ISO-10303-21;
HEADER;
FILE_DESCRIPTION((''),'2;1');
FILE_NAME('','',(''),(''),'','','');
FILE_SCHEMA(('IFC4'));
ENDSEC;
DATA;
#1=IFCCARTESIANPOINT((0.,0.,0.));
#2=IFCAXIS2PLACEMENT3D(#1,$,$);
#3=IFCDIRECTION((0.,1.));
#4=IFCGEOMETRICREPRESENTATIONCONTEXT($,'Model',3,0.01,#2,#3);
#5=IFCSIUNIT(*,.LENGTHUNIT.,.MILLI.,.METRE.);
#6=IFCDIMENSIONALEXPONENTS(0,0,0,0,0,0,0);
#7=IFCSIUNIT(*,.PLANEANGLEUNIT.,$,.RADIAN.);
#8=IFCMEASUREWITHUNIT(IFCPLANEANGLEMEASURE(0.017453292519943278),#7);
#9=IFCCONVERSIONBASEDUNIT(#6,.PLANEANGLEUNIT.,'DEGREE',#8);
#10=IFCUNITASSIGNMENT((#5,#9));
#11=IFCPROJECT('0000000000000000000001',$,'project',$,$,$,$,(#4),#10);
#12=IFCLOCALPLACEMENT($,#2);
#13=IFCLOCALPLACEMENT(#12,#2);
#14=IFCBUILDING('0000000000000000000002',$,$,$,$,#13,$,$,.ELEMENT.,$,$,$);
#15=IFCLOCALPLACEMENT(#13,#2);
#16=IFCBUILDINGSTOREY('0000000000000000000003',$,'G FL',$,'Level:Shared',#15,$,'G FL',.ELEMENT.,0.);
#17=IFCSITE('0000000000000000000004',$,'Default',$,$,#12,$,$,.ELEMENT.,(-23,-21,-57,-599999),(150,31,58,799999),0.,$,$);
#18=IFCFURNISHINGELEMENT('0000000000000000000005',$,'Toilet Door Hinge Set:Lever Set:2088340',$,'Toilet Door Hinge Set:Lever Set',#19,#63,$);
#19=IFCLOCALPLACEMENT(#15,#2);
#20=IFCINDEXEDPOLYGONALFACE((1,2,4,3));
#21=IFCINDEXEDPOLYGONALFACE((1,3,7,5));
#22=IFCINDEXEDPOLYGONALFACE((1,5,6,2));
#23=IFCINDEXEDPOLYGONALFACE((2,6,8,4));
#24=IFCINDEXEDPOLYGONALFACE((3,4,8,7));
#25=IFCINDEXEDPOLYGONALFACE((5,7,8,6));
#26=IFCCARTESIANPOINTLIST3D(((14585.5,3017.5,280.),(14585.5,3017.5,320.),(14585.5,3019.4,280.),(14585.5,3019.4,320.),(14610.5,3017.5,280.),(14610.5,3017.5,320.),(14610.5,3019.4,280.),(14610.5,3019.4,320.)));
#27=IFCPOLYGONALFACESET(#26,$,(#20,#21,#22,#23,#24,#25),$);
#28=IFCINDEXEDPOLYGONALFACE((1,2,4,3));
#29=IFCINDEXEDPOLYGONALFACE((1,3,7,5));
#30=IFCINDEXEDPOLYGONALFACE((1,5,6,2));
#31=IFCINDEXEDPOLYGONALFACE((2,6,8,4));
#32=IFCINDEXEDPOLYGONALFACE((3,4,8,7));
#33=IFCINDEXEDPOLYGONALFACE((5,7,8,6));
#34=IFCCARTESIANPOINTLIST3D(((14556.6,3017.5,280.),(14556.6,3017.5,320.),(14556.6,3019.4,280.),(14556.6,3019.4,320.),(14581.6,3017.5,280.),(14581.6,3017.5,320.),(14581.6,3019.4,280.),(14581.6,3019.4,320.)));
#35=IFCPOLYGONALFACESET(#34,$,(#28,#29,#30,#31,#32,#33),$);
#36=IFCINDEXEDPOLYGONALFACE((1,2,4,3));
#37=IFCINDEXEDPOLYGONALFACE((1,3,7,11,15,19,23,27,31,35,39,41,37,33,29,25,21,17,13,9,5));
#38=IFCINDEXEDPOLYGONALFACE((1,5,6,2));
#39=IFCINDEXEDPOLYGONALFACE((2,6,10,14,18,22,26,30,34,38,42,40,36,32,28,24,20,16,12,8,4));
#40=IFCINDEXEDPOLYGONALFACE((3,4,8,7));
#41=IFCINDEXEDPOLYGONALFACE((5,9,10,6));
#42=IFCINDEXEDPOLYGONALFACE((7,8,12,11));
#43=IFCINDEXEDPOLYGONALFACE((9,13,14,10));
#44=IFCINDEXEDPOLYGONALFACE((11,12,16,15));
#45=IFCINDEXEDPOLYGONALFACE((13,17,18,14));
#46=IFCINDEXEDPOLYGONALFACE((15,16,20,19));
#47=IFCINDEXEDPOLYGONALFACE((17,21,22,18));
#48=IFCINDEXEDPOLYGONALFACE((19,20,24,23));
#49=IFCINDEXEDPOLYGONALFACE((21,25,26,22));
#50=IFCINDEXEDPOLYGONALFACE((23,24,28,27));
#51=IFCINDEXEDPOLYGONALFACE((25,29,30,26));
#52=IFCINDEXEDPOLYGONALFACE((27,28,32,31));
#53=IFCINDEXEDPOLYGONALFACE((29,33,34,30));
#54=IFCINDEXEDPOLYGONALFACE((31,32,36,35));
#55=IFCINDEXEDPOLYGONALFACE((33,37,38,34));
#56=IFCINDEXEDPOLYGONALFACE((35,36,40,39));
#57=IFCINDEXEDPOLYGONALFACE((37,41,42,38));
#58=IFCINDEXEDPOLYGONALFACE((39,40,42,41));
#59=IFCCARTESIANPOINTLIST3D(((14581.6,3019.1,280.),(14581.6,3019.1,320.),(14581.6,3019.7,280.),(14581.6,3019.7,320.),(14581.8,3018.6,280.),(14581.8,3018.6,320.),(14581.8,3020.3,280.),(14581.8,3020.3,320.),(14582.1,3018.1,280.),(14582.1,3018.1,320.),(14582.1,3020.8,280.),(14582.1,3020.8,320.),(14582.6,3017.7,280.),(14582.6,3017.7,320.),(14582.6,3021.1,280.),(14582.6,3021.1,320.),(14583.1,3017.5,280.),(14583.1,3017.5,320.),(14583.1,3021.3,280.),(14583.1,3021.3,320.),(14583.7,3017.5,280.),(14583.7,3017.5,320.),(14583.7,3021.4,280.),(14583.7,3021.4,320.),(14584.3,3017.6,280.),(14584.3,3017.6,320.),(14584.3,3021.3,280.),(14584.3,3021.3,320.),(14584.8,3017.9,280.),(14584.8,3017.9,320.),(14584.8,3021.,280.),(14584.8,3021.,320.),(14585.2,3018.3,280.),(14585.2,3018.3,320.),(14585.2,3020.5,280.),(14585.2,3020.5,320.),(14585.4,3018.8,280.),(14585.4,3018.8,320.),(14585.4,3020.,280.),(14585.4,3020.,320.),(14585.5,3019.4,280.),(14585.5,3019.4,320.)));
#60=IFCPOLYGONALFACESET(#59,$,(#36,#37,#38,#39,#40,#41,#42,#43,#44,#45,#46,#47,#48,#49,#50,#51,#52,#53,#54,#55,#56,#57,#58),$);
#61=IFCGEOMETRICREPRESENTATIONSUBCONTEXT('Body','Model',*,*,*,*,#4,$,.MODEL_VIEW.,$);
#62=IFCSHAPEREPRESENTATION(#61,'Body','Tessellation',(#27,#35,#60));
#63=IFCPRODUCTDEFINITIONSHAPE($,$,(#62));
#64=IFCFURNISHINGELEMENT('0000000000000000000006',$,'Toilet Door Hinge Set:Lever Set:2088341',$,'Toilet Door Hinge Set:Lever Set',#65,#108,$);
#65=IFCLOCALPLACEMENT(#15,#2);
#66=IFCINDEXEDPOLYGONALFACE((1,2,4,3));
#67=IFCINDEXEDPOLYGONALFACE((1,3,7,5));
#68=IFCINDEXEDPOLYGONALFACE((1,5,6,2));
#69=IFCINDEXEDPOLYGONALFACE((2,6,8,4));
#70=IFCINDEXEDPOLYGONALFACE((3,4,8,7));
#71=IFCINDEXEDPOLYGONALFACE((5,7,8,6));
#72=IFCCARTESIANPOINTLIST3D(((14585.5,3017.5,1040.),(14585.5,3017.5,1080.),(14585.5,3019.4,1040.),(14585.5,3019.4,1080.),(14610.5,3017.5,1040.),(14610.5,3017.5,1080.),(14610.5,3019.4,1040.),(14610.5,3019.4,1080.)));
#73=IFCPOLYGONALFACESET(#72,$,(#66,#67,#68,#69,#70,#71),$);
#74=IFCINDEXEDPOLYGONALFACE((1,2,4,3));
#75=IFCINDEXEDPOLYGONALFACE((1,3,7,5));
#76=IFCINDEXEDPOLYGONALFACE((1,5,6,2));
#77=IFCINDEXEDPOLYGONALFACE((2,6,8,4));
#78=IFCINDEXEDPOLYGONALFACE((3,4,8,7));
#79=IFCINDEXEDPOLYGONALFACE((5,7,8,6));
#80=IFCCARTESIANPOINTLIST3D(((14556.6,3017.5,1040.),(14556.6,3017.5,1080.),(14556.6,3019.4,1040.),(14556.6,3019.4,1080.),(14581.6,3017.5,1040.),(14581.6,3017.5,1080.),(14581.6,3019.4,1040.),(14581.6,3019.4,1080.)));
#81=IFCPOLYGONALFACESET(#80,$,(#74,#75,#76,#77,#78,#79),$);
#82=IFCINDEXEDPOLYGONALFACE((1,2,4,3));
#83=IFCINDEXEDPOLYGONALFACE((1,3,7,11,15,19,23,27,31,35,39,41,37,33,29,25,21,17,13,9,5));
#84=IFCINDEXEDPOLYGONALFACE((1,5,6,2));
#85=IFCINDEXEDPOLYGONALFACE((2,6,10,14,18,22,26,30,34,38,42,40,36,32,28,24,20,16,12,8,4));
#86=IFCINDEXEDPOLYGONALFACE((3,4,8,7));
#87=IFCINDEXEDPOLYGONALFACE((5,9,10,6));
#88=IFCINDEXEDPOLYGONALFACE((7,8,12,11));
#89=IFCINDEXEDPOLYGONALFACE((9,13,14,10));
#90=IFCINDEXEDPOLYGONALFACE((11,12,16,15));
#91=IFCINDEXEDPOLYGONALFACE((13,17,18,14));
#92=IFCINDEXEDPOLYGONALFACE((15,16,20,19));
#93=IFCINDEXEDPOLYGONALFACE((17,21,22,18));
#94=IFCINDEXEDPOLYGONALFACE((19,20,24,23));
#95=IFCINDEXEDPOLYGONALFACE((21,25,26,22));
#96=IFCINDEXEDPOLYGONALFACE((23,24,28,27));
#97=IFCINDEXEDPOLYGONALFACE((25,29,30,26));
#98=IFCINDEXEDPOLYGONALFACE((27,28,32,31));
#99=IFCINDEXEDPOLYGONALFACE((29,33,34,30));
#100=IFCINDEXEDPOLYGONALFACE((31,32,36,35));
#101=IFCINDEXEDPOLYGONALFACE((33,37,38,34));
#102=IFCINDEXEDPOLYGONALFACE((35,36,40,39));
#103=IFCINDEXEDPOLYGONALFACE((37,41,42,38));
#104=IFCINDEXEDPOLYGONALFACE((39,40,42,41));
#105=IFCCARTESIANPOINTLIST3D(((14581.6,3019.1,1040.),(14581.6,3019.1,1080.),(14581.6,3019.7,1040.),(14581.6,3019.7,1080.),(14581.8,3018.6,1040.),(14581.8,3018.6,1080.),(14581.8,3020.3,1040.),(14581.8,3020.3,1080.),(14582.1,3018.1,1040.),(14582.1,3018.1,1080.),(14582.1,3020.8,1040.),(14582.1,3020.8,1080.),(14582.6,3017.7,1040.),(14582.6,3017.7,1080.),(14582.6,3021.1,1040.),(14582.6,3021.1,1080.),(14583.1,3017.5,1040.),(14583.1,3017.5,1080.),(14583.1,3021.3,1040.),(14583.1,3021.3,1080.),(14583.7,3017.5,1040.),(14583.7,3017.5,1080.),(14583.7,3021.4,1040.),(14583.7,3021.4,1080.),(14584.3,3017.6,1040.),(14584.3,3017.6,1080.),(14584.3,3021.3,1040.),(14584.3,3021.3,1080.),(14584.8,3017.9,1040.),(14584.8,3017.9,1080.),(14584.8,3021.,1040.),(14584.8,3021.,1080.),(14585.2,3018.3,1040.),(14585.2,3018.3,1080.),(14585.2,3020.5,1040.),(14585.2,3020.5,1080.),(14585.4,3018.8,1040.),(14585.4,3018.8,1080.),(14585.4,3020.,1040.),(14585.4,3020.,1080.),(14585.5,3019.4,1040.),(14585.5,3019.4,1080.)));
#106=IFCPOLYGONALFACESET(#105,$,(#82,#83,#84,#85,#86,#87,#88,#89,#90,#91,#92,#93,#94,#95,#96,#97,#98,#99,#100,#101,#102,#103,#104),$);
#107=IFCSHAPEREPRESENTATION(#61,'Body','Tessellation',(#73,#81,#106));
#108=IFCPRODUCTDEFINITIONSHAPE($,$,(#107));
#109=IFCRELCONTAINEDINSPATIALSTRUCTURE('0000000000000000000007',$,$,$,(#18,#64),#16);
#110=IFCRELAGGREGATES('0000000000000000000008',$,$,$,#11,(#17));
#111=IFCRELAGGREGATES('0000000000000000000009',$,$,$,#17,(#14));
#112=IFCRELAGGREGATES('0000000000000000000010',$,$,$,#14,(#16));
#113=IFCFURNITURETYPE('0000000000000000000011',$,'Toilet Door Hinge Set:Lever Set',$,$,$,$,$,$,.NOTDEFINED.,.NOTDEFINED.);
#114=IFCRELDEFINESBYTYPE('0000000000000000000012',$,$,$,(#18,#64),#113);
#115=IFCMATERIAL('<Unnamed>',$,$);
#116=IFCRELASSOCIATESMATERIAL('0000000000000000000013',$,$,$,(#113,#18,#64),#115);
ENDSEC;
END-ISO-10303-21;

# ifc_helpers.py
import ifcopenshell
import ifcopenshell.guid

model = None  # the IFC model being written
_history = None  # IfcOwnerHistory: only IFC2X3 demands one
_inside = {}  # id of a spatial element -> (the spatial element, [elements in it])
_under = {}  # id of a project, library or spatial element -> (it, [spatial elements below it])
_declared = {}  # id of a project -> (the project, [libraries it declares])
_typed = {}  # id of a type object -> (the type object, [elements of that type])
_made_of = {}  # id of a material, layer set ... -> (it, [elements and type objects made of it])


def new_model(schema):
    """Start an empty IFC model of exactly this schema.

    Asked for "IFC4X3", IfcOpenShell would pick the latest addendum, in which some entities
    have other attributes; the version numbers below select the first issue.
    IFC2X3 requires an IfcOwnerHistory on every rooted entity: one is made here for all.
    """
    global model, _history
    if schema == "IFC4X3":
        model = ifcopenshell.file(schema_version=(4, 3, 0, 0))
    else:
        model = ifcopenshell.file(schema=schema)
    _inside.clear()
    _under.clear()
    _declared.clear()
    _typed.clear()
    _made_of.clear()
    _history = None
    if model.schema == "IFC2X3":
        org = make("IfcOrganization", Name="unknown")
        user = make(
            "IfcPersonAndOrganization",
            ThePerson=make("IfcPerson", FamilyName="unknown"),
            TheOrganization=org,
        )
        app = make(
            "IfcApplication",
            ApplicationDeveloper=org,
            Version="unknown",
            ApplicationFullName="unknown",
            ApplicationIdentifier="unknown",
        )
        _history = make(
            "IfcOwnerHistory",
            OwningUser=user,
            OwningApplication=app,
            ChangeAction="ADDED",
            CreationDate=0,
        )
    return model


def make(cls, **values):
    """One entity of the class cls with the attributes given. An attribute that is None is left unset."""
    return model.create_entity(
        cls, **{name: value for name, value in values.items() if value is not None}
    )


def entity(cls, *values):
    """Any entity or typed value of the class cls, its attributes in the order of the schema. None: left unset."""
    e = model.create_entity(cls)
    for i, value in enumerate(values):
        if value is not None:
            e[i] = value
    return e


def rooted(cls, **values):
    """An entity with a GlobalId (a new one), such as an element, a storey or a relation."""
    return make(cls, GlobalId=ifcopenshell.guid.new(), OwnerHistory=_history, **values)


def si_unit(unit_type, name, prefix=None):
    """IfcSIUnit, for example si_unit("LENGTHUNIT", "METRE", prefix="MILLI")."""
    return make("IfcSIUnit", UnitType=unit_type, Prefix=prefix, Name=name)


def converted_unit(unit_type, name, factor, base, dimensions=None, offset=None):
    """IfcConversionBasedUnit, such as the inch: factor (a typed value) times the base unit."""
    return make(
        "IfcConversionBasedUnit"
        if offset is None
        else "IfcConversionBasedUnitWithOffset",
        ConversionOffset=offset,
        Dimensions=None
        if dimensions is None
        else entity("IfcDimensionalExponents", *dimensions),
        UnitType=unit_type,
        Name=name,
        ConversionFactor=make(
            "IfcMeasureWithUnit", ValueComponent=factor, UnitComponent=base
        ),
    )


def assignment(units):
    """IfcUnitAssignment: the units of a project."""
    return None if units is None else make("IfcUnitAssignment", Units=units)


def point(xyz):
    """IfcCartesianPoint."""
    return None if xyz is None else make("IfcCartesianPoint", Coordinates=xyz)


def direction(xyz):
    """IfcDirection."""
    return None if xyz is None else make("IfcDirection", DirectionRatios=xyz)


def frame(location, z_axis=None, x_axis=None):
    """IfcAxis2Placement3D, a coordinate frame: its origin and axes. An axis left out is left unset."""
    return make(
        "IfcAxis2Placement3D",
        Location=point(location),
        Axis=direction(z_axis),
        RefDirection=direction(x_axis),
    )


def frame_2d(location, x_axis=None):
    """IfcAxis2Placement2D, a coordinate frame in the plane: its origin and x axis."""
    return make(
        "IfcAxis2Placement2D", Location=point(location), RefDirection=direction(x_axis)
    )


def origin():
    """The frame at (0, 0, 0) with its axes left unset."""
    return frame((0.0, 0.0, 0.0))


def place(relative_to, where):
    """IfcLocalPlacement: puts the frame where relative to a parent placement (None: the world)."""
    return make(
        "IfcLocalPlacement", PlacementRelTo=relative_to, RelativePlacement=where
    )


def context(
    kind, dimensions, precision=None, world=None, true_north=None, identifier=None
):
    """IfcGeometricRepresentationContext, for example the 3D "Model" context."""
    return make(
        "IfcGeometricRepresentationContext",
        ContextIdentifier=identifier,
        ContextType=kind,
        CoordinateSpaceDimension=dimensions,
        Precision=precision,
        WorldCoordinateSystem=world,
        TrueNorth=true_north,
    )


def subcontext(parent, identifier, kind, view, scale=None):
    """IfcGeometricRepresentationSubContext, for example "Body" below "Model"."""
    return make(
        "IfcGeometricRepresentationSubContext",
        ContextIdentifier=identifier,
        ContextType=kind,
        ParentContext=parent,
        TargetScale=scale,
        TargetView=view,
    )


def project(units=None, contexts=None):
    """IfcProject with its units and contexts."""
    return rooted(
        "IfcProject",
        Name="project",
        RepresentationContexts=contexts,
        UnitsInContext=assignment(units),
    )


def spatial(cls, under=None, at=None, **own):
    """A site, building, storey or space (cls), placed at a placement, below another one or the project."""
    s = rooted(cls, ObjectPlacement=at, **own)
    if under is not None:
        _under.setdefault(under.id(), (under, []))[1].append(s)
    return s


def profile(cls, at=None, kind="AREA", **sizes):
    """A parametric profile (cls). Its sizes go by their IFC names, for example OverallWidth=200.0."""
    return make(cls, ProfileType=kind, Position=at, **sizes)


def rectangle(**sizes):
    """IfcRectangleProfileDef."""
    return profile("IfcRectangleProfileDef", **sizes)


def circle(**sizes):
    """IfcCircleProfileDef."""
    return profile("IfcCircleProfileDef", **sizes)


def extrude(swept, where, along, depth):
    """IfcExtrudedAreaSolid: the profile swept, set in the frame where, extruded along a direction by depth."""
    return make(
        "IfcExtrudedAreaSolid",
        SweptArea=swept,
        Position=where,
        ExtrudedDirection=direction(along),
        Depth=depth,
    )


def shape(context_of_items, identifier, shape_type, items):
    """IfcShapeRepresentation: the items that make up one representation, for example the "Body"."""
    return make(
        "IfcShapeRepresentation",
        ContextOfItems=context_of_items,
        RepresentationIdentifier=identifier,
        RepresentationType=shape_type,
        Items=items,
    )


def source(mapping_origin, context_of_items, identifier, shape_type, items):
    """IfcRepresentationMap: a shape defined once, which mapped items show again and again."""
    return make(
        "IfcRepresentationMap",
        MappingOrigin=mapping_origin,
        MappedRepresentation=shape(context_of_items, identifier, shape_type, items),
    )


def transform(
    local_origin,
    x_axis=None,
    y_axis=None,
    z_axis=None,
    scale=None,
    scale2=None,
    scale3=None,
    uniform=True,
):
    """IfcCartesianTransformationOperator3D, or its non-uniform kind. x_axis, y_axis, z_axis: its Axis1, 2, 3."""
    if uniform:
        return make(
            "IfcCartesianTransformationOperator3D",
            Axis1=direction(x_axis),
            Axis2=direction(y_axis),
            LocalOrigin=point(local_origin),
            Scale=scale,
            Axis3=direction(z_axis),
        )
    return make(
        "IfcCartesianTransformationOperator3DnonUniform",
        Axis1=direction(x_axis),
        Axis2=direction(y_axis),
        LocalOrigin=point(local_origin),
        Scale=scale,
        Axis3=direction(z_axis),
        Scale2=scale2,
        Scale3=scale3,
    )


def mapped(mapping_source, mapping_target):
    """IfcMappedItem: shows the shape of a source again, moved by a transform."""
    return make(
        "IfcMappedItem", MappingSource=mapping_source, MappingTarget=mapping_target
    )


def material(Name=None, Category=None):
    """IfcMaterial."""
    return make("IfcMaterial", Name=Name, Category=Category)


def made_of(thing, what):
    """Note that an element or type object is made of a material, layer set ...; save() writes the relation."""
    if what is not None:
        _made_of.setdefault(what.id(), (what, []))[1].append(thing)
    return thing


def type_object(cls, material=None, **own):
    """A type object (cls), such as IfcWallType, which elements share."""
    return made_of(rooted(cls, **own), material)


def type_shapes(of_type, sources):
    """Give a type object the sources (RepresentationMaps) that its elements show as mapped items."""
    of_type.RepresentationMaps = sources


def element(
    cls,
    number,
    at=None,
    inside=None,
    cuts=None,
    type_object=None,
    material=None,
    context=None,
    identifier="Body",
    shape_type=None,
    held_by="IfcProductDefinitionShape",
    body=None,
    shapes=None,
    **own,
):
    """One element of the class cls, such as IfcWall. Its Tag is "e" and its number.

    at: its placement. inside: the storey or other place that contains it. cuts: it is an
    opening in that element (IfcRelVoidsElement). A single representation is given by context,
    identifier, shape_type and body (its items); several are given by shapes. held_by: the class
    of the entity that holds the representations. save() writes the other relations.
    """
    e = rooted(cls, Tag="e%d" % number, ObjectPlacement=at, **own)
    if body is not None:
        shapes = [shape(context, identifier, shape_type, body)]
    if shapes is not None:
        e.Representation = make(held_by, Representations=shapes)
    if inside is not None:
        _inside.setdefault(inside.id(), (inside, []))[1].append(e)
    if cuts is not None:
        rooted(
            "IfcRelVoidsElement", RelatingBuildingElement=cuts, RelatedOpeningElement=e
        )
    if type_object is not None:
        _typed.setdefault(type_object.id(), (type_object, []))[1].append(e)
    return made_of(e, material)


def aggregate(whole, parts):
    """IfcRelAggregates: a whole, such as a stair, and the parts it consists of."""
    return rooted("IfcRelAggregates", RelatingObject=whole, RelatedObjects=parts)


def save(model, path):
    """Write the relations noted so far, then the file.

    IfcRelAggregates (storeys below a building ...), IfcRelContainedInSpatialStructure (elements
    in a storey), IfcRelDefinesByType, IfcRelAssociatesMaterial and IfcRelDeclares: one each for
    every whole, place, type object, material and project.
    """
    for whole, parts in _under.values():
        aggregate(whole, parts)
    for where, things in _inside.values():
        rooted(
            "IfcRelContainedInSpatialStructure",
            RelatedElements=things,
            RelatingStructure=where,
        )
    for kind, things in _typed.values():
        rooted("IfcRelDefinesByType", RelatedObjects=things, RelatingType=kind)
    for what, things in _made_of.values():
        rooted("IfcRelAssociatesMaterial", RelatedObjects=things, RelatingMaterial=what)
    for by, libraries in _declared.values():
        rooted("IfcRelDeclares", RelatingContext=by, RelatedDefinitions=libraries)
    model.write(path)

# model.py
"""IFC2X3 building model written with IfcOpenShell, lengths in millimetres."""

from ifc_helpers import new_model, entity, si_unit, converted_unit, direction, frame, frame_2d, origin, place, context, subcontext, project, spatial, rectangle, circle, extrude, source, transform, mapped, material, type_object, type_shapes, element, save


model = new_model("IFC2X3")

# Units and contexts
model_context = context("Model", 3, precision=0.01, world=origin(), true_north=direction((0.0, 1.0)))
body_context = subcontext(model_context, "Body", "Model", "MODEL_VIEW")
ifc_project = project(units=[si_unit("LENGTHUNIT", "METRE", prefix="MILLI"), converted_unit("PLANEANGLEUNIT", "DEGREE", entity("IfcPlaneAngleMeasure", 0.017453292519943278), si_unit("PLANEANGLEUNIT", "RADIAN"), dimensions=[0, 0, 0, 0, 0, 0, 0])], contexts=[model_context])

# Site, building, storey
site_placement = place(None, origin())
site = spatial("IfcSite", under=ifc_project, at=site_placement, Name="Default", CompositionType="ELEMENT", RefLatitude=(-23, -21, -57, -599999), RefLongitude=(150, 31, 58, 799999), RefElevation=0.0)
building_placement = place(site_placement, origin())
building = spatial("IfcBuilding", under=site, at=building_placement, CompositionType="ELEMENT")
storey_placement = place(building_placement, origin())
storey = spatial("IfcBuildingStorey", under=building, at=storey_placement, Name="G FL", ObjectType="Level:Shared", LongName="G FL", CompositionType="ELEMENT", Elevation=0.0)

# Furnishing elements
ifc_material_1 = material(Name="<Unnamed>")
furniture_type_1 = type_object("IfcFurnitureType", Name="Toilet Door Hinge Set:Lever Set", AssemblyPlace="NOTDEFINED", material=ifc_material_1)
shared_shape_1 = source(origin(), body_context, "Body", "SweptSolid", [
    extrude(rectangle(XDim=25.0, YDim=2.0, at=frame_2d((0.0, 0.0), x_axis=(1.0, 0.0))), frame((14.5, -1.0, -20.0), z_axis=(0.0, 0.0, 1.0), x_axis=(-1.0, 0.0, 0.0)), (0.0, 0.0, 1.0), 40.0),
    extrude(rectangle(XDim=2.0, YDim=25.0, at=frame_2d((0.0, 0.0), x_axis=(1.0, 0.0))), frame((-14.5, -1.0, -20.0), z_axis=(0.0, 0.0, 1.0), x_axis=(0.0, -1.0, 0.0)), (0.0, 0.0, 1.0), 40.0),
    extrude(circle(Radius=2.0, at=frame_2d((0.0, 0.0), x_axis=(1.0, 0.0))), frame((0.0, 0.0, -20.0)), (0.0, 0.0, 1.0), 40.0),
])
type_shapes(furniture_type_1, [shared_shape_1])
for number, where, name in (
    (1, (14583.5, 3019.4, 300.0), "Toilet Door Hinge Set:Lever Set:2088340"),
    (2, (14583.5, 3019.4, 1060.0), "Toilet Door Hinge Set:Lever Set:2088341"),
):
    element("IfcFurnishingElement", number, at=place(storey_placement, frame(where)), inside=storey, type_object=furniture_type_1, material=ifc_material_1, Name=name, ObjectType="Toilet Door Hinge Set:Lever Set", context=body_context, shape_type="MappedRepresentation", body=[
        mapped(shared_shape_1, transform((0.0, 0.0, 0.0), scale=1.0)),
    ])

save(model, "model.ifc")
